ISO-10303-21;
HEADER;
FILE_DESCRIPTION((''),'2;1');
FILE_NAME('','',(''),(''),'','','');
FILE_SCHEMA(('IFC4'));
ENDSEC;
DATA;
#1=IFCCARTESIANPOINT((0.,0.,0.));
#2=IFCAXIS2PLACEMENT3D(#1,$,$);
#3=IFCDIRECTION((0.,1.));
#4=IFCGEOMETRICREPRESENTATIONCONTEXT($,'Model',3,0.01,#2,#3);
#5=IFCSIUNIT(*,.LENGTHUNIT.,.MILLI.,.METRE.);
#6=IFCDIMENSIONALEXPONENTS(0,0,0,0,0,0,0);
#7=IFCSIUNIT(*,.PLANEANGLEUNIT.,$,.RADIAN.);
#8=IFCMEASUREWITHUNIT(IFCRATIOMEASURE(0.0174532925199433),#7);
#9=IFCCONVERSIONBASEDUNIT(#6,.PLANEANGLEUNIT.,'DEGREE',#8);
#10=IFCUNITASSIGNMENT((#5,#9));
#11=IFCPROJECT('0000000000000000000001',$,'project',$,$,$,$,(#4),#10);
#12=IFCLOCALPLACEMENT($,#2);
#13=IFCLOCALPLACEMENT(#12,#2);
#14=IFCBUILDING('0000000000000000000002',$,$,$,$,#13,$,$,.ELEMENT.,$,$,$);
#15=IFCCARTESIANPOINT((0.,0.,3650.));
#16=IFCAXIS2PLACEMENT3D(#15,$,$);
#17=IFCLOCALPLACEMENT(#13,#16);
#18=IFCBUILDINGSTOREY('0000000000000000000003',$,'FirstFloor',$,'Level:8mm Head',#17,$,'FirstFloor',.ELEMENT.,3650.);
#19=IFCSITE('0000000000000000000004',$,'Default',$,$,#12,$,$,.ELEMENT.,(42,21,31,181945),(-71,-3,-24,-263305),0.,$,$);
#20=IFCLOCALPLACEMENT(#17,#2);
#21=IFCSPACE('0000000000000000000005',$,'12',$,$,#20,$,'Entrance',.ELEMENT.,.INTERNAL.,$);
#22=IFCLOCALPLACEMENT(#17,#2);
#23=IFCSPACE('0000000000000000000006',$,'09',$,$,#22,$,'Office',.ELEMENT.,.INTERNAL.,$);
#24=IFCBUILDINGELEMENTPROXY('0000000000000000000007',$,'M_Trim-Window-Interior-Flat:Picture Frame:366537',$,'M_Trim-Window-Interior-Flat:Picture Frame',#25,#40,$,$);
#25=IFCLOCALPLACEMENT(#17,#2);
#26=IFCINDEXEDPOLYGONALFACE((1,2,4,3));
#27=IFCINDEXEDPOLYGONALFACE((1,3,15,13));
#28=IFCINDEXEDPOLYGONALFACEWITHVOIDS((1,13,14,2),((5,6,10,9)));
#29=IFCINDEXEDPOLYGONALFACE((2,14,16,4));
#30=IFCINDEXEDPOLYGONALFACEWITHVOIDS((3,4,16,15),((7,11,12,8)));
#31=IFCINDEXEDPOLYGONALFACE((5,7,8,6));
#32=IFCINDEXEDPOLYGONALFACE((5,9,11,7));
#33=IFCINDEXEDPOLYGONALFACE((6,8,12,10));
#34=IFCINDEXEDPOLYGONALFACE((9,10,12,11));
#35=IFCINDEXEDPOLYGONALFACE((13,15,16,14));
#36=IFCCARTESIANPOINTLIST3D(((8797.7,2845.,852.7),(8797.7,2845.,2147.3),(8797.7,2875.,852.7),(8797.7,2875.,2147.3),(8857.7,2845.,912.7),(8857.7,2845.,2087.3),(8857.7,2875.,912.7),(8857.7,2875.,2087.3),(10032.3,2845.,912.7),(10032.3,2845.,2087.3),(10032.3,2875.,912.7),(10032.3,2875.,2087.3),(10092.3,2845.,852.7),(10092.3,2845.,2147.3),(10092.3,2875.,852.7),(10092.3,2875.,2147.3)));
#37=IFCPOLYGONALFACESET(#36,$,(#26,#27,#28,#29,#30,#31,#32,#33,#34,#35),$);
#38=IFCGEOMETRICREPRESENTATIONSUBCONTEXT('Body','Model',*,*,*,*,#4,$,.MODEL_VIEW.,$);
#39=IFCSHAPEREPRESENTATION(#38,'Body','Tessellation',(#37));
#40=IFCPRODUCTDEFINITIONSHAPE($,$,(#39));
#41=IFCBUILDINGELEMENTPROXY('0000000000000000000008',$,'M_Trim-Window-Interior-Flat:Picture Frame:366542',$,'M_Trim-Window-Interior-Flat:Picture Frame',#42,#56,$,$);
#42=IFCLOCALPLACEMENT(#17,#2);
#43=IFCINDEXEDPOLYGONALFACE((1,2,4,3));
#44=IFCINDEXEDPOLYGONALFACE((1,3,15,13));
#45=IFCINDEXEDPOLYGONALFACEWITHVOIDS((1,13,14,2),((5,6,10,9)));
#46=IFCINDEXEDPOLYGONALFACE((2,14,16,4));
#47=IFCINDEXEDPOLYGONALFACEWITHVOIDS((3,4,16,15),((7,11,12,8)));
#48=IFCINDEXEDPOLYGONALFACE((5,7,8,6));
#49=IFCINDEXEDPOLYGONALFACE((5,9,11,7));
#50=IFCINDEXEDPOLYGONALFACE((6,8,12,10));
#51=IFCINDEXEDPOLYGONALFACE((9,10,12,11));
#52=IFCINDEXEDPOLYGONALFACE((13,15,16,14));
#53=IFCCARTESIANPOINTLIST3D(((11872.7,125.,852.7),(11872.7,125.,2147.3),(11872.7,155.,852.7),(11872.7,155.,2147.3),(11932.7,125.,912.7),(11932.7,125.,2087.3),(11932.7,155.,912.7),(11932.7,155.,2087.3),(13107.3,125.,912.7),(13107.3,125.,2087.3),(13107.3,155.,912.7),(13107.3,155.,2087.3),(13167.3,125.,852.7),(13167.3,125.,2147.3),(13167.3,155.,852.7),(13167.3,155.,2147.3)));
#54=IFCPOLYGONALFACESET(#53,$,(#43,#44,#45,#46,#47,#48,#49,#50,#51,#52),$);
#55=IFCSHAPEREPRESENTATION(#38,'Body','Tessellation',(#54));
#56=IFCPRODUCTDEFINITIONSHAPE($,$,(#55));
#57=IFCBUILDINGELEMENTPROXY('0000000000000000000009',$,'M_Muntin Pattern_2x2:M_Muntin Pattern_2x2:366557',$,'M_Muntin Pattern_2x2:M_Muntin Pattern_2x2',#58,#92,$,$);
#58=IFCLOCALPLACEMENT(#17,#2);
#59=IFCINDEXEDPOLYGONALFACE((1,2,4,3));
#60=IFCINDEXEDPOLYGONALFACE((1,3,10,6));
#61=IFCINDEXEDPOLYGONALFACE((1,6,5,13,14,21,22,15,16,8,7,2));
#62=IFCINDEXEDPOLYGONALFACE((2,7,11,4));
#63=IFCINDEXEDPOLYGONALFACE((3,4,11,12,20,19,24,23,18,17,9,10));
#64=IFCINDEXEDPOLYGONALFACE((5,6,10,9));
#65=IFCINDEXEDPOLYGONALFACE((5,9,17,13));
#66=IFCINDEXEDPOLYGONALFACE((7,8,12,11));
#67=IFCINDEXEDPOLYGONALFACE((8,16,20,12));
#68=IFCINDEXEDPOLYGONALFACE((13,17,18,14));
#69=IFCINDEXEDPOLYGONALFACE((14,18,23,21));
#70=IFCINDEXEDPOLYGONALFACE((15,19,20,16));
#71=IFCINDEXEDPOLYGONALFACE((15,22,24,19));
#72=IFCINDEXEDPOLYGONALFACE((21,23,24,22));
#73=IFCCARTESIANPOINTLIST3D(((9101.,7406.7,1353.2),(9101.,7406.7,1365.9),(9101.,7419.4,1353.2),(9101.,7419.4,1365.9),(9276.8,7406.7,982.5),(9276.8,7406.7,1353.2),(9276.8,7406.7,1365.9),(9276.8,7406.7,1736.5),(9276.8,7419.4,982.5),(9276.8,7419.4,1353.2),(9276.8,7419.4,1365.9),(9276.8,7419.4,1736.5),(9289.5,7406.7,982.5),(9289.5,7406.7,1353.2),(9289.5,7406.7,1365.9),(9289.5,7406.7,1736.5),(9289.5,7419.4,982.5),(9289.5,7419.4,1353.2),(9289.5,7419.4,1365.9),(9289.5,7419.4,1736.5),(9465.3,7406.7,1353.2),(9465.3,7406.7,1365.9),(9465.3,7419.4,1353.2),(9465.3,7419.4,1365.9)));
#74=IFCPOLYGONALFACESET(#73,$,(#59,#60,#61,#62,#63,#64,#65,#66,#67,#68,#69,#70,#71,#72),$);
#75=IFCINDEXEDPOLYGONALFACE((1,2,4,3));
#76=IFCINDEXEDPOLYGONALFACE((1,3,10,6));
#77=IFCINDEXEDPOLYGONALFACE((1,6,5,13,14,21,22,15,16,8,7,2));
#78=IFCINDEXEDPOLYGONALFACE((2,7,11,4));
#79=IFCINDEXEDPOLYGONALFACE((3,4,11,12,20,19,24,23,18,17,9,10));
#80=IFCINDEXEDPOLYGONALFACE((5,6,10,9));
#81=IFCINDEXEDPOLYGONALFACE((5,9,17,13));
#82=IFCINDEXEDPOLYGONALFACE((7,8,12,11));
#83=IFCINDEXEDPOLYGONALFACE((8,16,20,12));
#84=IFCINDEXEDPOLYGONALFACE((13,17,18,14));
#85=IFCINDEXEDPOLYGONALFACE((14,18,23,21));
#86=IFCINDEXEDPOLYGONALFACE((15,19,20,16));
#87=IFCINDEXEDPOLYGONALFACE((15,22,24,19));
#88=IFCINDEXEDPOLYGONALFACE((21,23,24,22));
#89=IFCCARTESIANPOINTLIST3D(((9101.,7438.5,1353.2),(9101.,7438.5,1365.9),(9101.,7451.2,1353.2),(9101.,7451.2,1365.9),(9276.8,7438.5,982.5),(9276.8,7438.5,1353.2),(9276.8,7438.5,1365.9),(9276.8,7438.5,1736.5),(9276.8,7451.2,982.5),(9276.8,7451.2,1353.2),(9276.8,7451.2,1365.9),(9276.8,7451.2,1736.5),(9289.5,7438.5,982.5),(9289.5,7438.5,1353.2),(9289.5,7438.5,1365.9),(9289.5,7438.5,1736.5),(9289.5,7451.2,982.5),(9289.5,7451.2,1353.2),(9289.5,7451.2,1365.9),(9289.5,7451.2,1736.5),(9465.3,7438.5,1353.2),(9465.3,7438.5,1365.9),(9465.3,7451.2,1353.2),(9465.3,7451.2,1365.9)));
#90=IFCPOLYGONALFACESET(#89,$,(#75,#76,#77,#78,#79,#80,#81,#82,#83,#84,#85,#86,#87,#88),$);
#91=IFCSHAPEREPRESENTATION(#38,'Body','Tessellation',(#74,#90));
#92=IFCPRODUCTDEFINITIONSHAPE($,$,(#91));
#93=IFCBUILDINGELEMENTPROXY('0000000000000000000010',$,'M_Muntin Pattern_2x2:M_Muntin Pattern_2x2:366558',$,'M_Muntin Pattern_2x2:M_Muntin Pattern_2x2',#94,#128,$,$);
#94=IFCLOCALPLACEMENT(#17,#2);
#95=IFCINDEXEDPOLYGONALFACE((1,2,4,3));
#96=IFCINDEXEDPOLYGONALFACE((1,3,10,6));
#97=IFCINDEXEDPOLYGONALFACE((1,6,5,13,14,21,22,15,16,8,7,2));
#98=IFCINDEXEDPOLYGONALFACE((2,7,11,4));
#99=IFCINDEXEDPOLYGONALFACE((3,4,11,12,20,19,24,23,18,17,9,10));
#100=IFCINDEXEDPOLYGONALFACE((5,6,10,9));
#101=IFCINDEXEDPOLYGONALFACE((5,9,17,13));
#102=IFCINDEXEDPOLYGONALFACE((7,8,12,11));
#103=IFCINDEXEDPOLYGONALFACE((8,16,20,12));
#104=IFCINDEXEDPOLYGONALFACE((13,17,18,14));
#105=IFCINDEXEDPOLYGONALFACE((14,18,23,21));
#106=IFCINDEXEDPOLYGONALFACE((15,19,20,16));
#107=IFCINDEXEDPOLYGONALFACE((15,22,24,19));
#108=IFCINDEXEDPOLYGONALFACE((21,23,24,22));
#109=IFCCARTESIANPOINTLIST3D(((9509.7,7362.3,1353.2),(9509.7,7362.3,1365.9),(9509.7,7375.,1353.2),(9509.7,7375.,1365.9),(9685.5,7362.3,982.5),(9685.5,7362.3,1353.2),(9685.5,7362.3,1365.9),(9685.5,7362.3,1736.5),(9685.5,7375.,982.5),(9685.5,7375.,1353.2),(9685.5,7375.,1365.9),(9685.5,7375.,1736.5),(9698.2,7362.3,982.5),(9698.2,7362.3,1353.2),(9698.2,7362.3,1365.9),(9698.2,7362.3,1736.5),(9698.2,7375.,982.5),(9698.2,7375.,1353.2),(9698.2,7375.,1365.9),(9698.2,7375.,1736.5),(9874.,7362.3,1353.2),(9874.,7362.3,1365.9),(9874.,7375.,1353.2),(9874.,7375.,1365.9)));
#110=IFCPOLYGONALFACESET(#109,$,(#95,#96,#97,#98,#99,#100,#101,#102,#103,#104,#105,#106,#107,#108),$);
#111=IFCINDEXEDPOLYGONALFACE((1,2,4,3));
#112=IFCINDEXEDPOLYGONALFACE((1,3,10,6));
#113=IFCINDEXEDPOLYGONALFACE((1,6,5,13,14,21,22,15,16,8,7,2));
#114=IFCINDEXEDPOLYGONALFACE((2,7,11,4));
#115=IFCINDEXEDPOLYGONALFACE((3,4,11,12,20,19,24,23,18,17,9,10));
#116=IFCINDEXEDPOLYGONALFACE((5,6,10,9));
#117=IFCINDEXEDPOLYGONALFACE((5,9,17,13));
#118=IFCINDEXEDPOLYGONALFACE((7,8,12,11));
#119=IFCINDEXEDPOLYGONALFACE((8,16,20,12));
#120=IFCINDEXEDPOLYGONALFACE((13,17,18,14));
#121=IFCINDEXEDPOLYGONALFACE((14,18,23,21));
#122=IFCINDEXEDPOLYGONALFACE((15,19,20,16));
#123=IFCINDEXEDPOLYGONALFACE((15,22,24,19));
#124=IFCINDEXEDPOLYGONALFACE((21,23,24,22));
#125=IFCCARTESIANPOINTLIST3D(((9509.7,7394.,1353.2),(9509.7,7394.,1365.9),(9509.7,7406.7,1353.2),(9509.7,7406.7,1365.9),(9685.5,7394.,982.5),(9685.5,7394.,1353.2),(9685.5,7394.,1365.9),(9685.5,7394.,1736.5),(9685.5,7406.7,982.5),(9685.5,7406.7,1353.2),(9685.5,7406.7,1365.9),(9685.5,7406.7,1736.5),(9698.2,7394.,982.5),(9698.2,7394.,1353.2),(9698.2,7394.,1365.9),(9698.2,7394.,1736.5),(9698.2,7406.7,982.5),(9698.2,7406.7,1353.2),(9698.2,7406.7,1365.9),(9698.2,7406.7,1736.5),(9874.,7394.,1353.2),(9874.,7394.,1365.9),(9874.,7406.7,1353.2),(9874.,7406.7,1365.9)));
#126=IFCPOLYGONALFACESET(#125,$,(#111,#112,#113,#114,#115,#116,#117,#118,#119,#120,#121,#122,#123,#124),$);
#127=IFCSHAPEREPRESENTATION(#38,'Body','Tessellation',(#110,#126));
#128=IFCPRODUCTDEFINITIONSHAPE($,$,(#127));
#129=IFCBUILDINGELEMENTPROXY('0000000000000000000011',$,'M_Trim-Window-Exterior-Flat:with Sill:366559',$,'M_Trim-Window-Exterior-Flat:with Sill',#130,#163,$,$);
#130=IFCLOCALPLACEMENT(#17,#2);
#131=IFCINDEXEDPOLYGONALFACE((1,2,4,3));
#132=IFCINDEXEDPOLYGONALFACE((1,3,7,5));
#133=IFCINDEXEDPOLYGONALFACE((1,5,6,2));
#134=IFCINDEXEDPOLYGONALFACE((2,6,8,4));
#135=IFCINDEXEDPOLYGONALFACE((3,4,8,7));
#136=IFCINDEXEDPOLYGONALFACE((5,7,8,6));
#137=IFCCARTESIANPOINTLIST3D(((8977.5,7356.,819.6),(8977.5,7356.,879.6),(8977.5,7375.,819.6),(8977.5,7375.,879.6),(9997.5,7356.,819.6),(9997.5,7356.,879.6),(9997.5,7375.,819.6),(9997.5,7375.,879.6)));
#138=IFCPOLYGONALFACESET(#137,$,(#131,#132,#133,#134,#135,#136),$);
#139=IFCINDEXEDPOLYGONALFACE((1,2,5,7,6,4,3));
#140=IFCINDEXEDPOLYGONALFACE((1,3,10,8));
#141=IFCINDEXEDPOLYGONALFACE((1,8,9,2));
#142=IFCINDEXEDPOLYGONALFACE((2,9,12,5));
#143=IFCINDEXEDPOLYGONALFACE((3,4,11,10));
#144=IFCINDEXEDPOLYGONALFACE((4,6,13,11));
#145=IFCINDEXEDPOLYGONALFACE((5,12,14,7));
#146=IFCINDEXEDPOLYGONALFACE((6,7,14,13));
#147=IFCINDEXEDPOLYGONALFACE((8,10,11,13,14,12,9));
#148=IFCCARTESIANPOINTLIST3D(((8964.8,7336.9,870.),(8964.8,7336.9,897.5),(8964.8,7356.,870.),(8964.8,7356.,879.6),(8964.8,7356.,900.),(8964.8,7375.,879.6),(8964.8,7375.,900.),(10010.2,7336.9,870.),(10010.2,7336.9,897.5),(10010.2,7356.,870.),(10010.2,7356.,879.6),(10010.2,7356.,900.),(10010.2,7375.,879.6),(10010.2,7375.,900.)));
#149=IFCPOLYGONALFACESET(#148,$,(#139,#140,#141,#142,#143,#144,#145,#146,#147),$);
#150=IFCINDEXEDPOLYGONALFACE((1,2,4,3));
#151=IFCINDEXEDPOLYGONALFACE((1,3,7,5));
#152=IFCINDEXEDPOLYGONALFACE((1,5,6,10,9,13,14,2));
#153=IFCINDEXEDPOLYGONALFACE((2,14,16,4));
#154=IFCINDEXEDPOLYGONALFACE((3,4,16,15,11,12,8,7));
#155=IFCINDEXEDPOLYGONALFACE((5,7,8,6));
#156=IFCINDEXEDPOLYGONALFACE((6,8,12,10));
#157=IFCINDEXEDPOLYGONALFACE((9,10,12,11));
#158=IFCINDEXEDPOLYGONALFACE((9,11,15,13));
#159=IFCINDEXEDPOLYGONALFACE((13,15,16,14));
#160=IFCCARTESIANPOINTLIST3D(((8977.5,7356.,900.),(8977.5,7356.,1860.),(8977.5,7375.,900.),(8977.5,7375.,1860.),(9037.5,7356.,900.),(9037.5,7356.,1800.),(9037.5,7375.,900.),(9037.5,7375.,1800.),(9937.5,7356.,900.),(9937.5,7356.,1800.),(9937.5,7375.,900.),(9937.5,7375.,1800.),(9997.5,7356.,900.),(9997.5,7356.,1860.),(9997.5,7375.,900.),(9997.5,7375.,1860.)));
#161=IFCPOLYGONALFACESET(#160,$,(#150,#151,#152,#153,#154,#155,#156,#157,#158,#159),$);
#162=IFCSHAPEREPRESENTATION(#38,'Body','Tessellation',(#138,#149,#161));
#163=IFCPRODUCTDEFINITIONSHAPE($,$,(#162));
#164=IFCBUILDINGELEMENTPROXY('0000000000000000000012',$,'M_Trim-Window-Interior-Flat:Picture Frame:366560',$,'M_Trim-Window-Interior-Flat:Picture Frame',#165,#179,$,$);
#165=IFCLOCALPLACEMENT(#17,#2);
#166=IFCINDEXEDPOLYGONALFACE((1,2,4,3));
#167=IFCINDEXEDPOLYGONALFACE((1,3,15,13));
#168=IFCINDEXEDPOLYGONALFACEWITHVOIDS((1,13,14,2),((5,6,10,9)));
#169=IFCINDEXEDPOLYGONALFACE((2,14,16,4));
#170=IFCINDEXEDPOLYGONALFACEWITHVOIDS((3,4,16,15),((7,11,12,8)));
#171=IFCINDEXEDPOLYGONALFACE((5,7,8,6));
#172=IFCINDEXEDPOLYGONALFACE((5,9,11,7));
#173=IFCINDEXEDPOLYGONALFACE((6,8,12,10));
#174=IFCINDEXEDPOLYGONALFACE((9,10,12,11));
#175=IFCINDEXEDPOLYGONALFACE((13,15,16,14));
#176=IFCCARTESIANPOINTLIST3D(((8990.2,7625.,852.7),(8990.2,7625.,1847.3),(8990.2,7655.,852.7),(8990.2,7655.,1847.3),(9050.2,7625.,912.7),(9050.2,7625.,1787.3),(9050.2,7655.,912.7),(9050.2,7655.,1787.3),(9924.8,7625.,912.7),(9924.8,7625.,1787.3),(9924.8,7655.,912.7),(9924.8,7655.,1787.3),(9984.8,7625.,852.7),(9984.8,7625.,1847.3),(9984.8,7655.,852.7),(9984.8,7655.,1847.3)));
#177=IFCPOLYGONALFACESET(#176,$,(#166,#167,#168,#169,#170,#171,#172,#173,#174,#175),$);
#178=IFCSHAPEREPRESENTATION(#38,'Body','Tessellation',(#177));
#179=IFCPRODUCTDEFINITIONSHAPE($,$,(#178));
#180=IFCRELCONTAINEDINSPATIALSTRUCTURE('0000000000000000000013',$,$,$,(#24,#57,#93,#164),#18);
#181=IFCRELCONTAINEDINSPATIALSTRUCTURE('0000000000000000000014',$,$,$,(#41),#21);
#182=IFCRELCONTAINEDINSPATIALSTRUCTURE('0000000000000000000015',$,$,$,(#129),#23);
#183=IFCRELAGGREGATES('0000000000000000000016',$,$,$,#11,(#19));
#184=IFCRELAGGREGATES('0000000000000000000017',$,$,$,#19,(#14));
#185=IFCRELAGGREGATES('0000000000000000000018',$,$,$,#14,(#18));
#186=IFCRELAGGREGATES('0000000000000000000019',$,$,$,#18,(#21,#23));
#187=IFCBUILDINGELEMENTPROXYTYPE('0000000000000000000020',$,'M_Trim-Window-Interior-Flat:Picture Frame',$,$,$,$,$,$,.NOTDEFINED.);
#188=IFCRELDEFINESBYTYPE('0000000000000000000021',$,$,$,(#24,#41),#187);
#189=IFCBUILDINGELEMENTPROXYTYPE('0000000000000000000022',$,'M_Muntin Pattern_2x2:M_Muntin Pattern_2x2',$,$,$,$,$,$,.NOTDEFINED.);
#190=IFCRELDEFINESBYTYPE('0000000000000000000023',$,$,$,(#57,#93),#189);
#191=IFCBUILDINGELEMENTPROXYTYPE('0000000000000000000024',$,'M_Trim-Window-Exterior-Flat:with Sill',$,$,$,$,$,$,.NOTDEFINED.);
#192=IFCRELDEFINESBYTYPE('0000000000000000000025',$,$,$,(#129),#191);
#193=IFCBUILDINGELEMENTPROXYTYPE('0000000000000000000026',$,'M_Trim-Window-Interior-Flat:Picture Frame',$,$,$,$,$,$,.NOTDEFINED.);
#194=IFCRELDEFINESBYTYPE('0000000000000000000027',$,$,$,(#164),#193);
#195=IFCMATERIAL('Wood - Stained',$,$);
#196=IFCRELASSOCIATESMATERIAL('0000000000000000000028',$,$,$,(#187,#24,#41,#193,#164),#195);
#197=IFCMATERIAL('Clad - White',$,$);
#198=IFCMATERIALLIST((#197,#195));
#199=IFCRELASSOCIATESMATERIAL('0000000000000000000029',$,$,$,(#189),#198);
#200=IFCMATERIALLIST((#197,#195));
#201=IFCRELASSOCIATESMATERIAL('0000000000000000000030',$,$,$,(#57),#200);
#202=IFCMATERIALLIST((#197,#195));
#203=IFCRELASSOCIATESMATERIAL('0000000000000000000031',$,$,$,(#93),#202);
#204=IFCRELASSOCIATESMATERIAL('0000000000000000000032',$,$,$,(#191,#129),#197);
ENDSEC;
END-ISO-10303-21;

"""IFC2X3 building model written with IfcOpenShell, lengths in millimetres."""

from ifc_helpers import new_model, entity, si_unit, converted_unit, direction, frame, frame_2d, origin, place, context, subcontext, project, spatial, polyline, rectangle, outline, extrude, source, transform, mapped, material, material_list, type_object, type_shapes, element, save


model = new_model("IFC2X3")

# Units and contexts
model_context = context("Model", 3, precision=0.01, world=origin(), true_north=direction((0.0, 1.0)))
body_context = subcontext(model_context, "Body", "Model", "MODEL_VIEW")
ifc_project = project(units=[si_unit("LENGTHUNIT", "METRE", prefix="MILLI"), converted_unit("PLANEANGLEUNIT", "DEGREE", entity("IfcRatioMeasure", 0.0174532925199433), si_unit("PLANEANGLEUNIT", "RADIAN"), dimensions=[0, 0, 0, 0, 0, 0, 0])], contexts=[model_context])

# Site, building, storey
site_placement = place(None, origin())
site = spatial("IfcSite", under=ifc_project, at=site_placement, Name="Default", CompositionType="ELEMENT", RefLatitude=(42, 21, 31, 181945), RefLongitude=(-71, -3, -24, -263305), RefElevation=0.0)
building_placement = place(site_placement, origin())
building = spatial("IfcBuilding", under=site, at=building_placement, CompositionType="ELEMENT")
storey_placement = place(building_placement, frame((0.0, 0.0, 3650.0)))
storey = spatial("IfcBuildingStorey", under=building, at=storey_placement, Name="FirstFloor", ObjectType="Level:8mm Head", LongName="FirstFloor", CompositionType="ELEMENT", Elevation=3650.0)

# Shared definitions
ifc_material_1 = material(Name="Clad - White")
ifc_material_2 = material(Name="Wood - Stained")

# Building element proxy
building_element_proxy_type_1 = type_object("IfcBuildingElementProxyType", Name="M_Trim-Window-Interior-Flat:Picture Frame", PredefinedType="NOTDEFINED", material=ifc_material_2)
shared_shape_1 = source(origin(), body_context, "Body", "SweptSolid", [
    extrude(outline(polyline([(-647.3, -647.3), (647.3, -647.3), (647.3, 647.3), (-647.3, 647.3), (-647.3, -647.3)]), holes=[polyline([(-587.3, -587.3), (-587.3, 587.3), (587.3, 587.3), (587.3, -587.3), (-587.3, -587.3)])]), frame((0.0, -600.0, 0.0), z_axis=(0.0, 0.0, 1.0), x_axis=(-1.0, 0.0, 0.0)), (0.0, 0.0, 1.0), 30.0),
])
type_shapes(building_element_proxy_type_1, [shared_shape_1])
proxy_1_placement = place(storey_placement, frame((9445.0, 2875.0, 2100.0), z_axis=(0.0, -1.0, 0.0), x_axis=(1.0, 0.0, 0.0)))
element("IfcBuildingElementProxy", 1, at=proxy_1_placement, inside=storey, type_object=building_element_proxy_type_1, material=ifc_material_2, Name="M_Trim-Window-Interior-Flat:Picture Frame:366537", ObjectType="M_Trim-Window-Interior-Flat:Picture Frame", context=body_context, shape_type="MappedRepresentation", body=[
    mapped(shared_shape_1, transform((0.0, 0.0, 0.0), scale=1.0)),
])

# Shared definitions
space_1_placement = place(storey_placement, origin())
space_1 = spatial("IfcSpace", under=storey, at=space_1_placement, Name="12", LongName="Entrance", CompositionType="ELEMENT", InteriorOrExteriorSpace="INTERNAL")

# Building element proxies
proxy_2_placement = place(space_1_placement, frame((12520.0, 125.0, 2100.0), z_axis=(0.0, 1.0, 0.0), x_axis=(-1.0, 0.0, 0.0)))
element("IfcBuildingElementProxy", 2, at=proxy_2_placement, inside=space_1, type_object=building_element_proxy_type_1, material=ifc_material_2, Name="M_Trim-Window-Interior-Flat:Picture Frame:366542", ObjectType="M_Trim-Window-Interior-Flat:Picture Frame", context=body_context, shape_type="MappedRepresentation", body=[
    mapped(shared_shape_1, transform((0.0, 0.0, 0.0), scale=1.0)),
])
ifc_material_list_1 = material_list([ifc_material_1, ifc_material_2])
ifc_material_list_2 = material_list([ifc_material_1, ifc_material_2])
building_element_proxy_type_2 = type_object("IfcBuildingElementProxyType", Name="M_Muntin Pattern_2x2:M_Muntin Pattern_2x2", PredefinedType="NOTDEFINED", material=ifc_material_list_2)
shared_shape_2 = source(origin(), body_context, "Body", "SweptSolid", [
    extrude(outline(polyline([(6.4, -6.4), (377.0, -6.4), (377.0, 6.3), (6.4, 6.3), (6.4, 182.1), (-6.3, 182.1), (-6.3, 6.3), (-377.0, 6.3), (-377.0, -6.4), (-6.3, -6.4), (-6.3, -182.1), (6.4, -182.1), (6.4, -6.4)])), frame((0.0, 9.5, 377.0), z_axis=(0.0, 1.0, 0.0), x_axis=(0.0, 0.0, 1.0)), (0.0, 0.0, 1.0), 12.7),
    extrude(outline(polyline([(6.4, -6.4), (377.0, -6.4), (377.0, 6.3), (6.4, 6.3), (6.4, 182.1), (-6.3, 182.1), (-6.3, 6.3), (-377.0, 6.3), (-377.0, -6.4), (-6.3, -6.4), (-6.3, -182.1), (6.4, -182.1), (6.4, -6.4)])), frame((0.0, -22.2, 377.0), z_axis=(0.0, 1.0, 0.0), x_axis=(0.0, 0.0, 1.0)), (0.0, 0.0, 1.0), 12.7),
])
type_shapes(building_element_proxy_type_2, [shared_shape_2])
proxy_3_placement = place(storey_placement, frame((9283.1, 7429.0, 982.5), z_axis=(0.0, 0.0, 1.0), x_axis=(-1.0, 0.0, 0.0)))
element("IfcBuildingElementProxy", 3, at=proxy_3_placement, inside=storey, type_object=building_element_proxy_type_2, material=ifc_material_list_1, Name="M_Muntin Pattern_2x2:M_Muntin Pattern_2x2:366557", ObjectType="M_Muntin Pattern_2x2:M_Muntin Pattern_2x2", context=body_context, shape_type="MappedRepresentation", body=[
    mapped(shared_shape_2, transform((0.0, 0.0, 0.0), scale=1.0)),
])
ifc_material_list_3 = material_list([ifc_material_1, ifc_material_2])
proxy_4_placement = place(storey_placement, frame((9691.9, 7384.5, 982.5), z_axis=(0.0, 0.0, 1.0), x_axis=(-1.0, 0.0, 0.0)))
element("IfcBuildingElementProxy", 4, at=proxy_4_placement, inside=storey, type_object=building_element_proxy_type_2, material=ifc_material_list_3, Name="M_Muntin Pattern_2x2:M_Muntin Pattern_2x2:366558", ObjectType="M_Muntin Pattern_2x2:M_Muntin Pattern_2x2", context=body_context, shape_type="MappedRepresentation", body=[
    mapped(shared_shape_2, transform((0.0, 0.0, 0.0), scale=1.0)),
])

# Shared definitions
space_2_placement = place(storey_placement, origin())
space_2 = spatial("IfcSpace", under=storey, at=space_2_placement, Name="09", LongName="Office", CompositionType="ELEMENT", InteriorOrExteriorSpace="INTERNAL")

# Building element proxies
building_element_proxy_type_3 = type_object("IfcBuildingElementProxyType", Name="M_Trim-Window-Exterior-Flat:with Sill", PredefinedType="NOTDEFINED", material=ifc_material_1)
shared_shape_3 = source(origin(), body_context, "Body", "SweptSolid", [
    extrude(rectangle(XDim=1020.0, YDim=60.0, at=frame_2d((0.0, 0.0), x_axis=(1.0, 0.0))), frame((0.0, -950.4, 0.0), z_axis=(0.0, 0.0, 1.0), x_axis=(-1.0, 0.0, 0.0)), (0.0, 0.0, 1.0), 19.1),
    extrude(outline(polyline([(-19.0, -15.2), (0.0, -15.2), (0.0, -5.7), (19.0, -5.7), (19.0, 14.8), (0.0, 14.8), (-19.0, 12.3), (-19.0, -15.2)])), frame((-522.7, -914.8, 19.0), z_axis=(1.0, 0.0, 0.0), x_axis=(0.0, 0.0, -1.0)), (0.0, 0.0, 1.0), 1045.4),
    extrude(outline(polyline([(-495.0, -510.0), (465.0, -510.0), (465.0, -450.0), (-435.0, -450.0), (-435.0, 450.0), (465.0, 450.0), (465.0, 510.0), (-495.0, 510.0), (-495.0, -510.0)])), frame((0.0, -435.0, 0.0), z_axis=(0.0, 0.0, 1.0), x_axis=(0.0, -1.0, 0.0)), (0.0, 0.0, 1.0), 19.1),
])
type_shapes(building_element_proxy_type_3, [shared_shape_3])
proxy_5_placement = place(space_2_placement, frame((9487.5, 7375.0, 1800.0), z_axis=(0.0, -1.0, 0.0), x_axis=(1.0, 0.0, 0.0)))
element("IfcBuildingElementProxy", 5, at=proxy_5_placement, inside=space_2, type_object=building_element_proxy_type_3, material=ifc_material_1, Name="M_Trim-Window-Exterior-Flat:with Sill:366559", ObjectType="M_Trim-Window-Exterior-Flat:with Sill", context=body_context, shape_type="MappedRepresentation", body=[
    mapped(shared_shape_3, transform((0.0, 0.0, 0.0), scale=1.0)),
])
building_element_proxy_type_4 = type_object("IfcBuildingElementProxyType", Name="M_Trim-Window-Interior-Flat:Picture Frame", PredefinedType="NOTDEFINED", material=ifc_material_2)
shared_shape_4 = source(origin(), body_context, "Body", "SweptSolid", [
    extrude(outline(polyline([(-497.3, -497.3), (497.3, -497.3), (497.3, 497.3), (-497.3, 497.3), (-497.3, -497.3)]), holes=[polyline([(-437.3, -437.3), (-437.3, 437.3), (437.3, 437.3), (437.3, -437.3), (-437.3, -437.3)])]), frame((0.0, -450.0, 0.0), z_axis=(0.0, 0.0, 1.0), x_axis=(-1.0, 0.0, 0.0)), (0.0, 0.0, 1.0), 30.0),
])
type_shapes(building_element_proxy_type_4, [shared_shape_4])
proxy_6_placement = place(storey_placement, frame((9487.5, 7625.0, 1800.0), z_axis=(0.0, 1.0, 0.0), x_axis=(-1.0, 0.0, 0.0)))
element("IfcBuildingElementProxy", 6, at=proxy_6_placement, inside=storey, type_object=building_element_proxy_type_4, material=ifc_material_2, Name="M_Trim-Window-Interior-Flat:Picture Frame:366560", ObjectType="M_Trim-Window-Interior-Flat:Picture Frame", context=body_context, shape_type="MappedRepresentation", body=[
    mapped(shared_shape_4, transform((0.0, 0.0, 0.0), scale=1.0)),
])

save(model, "model.ifc")
